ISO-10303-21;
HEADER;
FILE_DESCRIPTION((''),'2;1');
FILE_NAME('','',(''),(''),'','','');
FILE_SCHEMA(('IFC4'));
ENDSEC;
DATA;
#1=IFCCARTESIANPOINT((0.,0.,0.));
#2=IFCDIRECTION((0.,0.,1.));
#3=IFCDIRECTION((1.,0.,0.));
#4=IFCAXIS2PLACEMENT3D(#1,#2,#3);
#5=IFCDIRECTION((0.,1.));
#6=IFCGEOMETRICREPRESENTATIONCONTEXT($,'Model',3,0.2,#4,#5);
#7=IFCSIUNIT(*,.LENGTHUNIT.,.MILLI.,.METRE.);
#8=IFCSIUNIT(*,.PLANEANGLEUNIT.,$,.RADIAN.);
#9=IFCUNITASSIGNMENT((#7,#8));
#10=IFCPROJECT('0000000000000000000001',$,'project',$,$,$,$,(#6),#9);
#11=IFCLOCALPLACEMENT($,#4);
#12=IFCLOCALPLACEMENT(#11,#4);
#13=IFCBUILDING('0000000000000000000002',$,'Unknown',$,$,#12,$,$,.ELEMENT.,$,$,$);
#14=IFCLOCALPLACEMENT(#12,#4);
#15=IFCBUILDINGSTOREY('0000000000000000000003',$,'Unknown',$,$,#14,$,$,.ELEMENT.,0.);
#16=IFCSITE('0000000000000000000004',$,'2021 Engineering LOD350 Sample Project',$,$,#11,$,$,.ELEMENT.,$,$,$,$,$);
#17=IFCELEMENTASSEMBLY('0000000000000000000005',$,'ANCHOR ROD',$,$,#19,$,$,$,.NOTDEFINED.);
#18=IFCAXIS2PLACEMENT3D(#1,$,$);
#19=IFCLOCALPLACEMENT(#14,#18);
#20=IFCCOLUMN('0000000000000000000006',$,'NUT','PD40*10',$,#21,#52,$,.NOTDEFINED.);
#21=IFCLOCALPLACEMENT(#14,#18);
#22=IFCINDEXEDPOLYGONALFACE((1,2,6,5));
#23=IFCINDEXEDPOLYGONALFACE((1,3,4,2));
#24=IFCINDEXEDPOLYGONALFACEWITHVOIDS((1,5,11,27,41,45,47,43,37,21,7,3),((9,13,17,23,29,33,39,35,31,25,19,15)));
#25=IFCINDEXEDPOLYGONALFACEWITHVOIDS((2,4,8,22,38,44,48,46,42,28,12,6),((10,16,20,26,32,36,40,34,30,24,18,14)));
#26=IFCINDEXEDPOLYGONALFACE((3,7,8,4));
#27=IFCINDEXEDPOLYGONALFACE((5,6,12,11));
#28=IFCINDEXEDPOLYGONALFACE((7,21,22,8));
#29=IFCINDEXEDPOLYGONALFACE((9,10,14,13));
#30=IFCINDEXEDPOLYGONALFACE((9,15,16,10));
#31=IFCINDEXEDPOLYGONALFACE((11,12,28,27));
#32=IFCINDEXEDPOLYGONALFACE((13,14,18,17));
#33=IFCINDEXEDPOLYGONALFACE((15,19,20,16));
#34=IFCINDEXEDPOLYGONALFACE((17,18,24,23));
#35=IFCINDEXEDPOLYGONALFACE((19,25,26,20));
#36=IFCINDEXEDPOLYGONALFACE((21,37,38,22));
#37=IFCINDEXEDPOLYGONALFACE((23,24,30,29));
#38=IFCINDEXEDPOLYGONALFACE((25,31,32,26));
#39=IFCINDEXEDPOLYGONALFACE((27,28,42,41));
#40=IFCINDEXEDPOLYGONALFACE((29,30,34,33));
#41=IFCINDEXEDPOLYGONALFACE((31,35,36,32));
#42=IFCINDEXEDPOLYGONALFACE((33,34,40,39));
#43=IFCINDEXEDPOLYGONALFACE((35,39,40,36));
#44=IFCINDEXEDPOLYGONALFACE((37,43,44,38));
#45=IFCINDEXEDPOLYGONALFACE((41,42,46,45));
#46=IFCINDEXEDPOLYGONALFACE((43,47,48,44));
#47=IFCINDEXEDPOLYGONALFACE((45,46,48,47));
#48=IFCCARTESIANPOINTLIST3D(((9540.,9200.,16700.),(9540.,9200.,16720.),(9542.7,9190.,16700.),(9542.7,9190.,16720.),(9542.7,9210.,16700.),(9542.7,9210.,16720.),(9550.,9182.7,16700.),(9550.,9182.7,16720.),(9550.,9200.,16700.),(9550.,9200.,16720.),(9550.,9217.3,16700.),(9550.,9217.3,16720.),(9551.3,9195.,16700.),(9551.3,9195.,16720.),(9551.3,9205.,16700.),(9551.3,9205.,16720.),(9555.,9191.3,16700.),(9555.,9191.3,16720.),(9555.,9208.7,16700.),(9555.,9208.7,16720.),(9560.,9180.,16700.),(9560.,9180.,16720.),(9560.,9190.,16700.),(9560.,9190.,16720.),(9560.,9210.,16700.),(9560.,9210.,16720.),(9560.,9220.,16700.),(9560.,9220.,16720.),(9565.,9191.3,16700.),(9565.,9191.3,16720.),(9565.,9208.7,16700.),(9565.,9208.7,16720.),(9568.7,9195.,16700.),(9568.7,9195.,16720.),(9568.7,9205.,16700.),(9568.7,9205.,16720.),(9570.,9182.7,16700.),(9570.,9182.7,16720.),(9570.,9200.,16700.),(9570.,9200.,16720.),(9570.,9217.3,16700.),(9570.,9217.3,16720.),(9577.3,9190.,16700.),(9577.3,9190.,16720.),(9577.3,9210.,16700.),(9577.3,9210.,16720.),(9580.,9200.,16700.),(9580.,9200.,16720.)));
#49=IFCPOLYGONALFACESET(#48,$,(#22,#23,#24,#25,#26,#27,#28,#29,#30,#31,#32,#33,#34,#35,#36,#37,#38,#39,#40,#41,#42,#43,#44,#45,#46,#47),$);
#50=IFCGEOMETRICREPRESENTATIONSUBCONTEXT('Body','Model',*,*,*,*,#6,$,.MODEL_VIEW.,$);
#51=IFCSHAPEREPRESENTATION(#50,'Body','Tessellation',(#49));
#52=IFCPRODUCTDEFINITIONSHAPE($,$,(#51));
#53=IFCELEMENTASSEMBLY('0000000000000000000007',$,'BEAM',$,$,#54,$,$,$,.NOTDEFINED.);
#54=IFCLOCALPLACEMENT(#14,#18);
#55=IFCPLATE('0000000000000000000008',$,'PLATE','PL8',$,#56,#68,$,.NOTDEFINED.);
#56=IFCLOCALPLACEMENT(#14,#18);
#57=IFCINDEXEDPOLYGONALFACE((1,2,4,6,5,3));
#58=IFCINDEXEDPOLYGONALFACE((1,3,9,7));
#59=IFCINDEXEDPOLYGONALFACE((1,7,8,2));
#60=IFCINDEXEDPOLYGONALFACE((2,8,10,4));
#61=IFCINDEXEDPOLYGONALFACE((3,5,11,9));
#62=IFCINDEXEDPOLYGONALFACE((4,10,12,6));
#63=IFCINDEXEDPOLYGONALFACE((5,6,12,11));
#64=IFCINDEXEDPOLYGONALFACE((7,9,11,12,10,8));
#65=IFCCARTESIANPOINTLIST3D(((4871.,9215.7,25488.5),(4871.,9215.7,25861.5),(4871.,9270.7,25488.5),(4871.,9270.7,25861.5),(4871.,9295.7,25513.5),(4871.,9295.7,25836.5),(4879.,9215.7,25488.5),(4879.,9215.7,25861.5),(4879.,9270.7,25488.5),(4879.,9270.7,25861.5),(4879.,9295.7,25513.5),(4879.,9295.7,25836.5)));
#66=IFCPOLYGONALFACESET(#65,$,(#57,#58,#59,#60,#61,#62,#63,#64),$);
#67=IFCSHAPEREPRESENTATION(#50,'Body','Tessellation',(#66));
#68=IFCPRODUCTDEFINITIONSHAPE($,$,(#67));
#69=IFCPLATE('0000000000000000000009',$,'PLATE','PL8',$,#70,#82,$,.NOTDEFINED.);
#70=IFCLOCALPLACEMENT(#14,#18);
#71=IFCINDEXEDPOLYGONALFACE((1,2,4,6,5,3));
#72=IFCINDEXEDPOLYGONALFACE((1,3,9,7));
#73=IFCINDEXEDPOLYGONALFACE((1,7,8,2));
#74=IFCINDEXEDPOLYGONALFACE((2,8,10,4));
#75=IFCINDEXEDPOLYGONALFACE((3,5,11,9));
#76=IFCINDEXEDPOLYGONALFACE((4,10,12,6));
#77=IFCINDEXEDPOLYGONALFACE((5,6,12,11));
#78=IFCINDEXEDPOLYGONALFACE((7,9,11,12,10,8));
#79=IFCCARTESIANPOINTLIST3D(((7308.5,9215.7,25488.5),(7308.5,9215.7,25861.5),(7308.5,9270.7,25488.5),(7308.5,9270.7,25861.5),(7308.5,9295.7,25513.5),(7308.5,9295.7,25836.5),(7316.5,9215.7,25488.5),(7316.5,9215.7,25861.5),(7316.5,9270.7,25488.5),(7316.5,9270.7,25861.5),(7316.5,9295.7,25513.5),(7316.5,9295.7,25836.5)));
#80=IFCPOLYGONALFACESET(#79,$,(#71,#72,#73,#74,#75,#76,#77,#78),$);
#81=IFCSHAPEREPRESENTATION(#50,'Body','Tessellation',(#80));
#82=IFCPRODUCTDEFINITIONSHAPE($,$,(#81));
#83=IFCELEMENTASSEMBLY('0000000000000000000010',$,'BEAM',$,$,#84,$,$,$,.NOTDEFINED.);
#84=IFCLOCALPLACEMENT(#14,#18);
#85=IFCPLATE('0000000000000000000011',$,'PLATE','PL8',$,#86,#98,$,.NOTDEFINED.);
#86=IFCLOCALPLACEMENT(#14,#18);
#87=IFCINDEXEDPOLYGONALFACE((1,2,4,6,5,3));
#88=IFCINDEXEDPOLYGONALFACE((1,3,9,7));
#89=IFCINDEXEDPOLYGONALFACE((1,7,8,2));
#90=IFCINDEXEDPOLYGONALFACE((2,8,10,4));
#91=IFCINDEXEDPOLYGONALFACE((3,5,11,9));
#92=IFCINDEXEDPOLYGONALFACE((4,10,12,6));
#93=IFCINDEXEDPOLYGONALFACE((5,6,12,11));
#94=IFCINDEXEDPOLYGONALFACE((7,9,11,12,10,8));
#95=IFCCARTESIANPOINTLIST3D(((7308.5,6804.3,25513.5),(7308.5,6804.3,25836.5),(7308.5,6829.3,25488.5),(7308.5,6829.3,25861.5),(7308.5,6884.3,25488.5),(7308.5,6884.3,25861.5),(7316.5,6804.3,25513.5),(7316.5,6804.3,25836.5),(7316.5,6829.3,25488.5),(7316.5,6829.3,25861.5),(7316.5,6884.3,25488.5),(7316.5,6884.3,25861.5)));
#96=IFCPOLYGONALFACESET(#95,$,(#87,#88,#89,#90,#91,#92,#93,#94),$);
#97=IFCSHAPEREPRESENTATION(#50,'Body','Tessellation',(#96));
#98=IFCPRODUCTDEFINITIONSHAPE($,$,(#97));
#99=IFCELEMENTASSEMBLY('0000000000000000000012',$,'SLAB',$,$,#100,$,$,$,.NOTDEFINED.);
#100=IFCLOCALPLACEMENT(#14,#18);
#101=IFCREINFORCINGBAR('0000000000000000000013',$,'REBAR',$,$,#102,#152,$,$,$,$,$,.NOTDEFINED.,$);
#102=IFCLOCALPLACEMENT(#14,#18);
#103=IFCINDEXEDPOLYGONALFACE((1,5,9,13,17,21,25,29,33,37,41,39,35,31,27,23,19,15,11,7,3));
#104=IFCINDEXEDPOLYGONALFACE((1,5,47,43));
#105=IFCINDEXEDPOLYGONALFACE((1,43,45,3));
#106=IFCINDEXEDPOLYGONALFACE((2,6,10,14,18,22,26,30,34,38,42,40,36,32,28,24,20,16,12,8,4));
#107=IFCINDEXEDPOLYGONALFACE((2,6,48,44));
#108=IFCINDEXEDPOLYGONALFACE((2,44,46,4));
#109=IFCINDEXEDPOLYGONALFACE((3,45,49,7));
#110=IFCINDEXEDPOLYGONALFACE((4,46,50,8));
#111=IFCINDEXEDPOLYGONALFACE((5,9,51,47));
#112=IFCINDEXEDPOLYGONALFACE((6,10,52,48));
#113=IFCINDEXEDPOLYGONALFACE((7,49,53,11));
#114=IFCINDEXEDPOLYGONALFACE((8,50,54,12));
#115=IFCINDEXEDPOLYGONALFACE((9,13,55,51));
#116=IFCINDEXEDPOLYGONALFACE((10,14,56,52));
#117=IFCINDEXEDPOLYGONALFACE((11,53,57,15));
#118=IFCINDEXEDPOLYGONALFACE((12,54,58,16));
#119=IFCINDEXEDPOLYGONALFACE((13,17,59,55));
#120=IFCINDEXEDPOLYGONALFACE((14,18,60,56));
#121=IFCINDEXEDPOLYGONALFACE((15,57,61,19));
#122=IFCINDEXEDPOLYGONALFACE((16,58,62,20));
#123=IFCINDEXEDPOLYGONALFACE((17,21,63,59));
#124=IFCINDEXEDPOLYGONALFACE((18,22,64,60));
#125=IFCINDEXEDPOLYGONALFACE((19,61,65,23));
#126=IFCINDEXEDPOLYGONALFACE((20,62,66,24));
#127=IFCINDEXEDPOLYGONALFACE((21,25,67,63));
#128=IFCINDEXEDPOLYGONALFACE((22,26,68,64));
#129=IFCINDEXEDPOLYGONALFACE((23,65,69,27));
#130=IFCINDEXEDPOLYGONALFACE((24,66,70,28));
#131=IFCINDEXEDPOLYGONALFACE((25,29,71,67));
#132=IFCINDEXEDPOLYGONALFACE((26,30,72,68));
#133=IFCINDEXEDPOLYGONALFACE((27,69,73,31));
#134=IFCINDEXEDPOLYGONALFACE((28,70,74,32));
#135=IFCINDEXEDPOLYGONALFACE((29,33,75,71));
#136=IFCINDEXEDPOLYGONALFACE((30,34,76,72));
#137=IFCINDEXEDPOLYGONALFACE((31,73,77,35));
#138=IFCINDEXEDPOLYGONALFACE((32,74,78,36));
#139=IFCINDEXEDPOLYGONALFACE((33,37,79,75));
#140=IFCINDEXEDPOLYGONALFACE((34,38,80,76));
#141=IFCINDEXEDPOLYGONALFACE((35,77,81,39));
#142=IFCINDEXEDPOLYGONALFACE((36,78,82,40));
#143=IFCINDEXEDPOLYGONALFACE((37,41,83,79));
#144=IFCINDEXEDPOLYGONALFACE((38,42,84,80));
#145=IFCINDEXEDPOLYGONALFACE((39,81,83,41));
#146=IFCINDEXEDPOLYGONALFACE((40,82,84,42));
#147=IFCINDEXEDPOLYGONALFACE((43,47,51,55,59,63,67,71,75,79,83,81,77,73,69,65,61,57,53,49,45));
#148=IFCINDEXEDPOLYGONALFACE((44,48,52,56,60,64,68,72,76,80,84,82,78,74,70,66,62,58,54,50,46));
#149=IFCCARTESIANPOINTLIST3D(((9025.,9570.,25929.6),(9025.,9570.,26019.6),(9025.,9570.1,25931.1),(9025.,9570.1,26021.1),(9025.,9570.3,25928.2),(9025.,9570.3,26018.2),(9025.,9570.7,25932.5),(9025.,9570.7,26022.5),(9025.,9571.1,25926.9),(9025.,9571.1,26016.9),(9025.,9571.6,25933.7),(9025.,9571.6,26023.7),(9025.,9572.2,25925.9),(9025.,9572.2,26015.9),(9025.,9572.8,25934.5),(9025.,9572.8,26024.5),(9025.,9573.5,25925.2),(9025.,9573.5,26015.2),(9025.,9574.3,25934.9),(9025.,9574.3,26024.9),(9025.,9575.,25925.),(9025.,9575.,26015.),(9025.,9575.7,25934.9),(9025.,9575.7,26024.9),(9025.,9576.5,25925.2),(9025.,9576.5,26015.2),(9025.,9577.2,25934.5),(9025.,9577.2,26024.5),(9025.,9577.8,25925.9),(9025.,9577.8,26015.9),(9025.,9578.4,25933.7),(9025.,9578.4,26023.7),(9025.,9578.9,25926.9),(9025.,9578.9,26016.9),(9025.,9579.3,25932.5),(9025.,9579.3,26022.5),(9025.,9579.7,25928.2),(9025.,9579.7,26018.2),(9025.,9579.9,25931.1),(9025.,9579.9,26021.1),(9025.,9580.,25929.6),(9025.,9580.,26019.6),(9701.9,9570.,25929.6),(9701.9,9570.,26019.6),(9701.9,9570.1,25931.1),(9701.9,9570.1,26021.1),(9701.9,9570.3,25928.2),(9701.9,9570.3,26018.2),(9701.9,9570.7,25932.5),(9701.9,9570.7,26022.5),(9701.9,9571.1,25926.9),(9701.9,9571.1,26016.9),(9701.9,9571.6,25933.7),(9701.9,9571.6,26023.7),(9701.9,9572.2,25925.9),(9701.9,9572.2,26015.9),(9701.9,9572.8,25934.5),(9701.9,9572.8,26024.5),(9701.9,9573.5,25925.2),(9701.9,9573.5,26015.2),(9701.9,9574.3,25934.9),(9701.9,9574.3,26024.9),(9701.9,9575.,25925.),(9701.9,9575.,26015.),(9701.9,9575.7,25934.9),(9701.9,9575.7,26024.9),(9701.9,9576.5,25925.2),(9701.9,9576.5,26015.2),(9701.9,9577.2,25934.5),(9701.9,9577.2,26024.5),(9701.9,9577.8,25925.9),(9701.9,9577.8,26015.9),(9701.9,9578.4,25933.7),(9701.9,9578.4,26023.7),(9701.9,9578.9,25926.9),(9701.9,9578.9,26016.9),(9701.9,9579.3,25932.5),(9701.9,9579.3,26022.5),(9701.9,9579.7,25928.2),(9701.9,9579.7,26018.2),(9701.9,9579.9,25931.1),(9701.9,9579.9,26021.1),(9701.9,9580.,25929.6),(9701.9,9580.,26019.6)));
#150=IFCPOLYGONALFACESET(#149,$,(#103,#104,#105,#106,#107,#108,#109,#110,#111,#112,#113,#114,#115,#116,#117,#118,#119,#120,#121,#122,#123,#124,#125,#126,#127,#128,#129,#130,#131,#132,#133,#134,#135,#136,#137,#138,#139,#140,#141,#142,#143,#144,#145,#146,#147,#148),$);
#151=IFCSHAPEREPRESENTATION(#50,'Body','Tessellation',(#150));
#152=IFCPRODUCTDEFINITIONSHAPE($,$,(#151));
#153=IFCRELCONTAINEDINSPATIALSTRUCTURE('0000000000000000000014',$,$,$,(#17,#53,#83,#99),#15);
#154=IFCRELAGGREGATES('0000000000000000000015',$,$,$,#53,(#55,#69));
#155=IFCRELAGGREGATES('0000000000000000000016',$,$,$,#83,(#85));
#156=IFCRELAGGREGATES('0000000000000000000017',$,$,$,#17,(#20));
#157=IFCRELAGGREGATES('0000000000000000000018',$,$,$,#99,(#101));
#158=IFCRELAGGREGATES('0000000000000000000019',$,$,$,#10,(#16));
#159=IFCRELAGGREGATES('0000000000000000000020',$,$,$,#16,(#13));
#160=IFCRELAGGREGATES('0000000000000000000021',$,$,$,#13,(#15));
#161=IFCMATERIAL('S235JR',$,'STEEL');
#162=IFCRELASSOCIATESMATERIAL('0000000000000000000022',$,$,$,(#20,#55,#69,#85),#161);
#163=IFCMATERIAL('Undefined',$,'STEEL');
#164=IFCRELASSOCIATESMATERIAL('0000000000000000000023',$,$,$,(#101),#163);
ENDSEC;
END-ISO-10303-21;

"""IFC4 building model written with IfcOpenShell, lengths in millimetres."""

from ifc_helpers import new_model, entity, si_unit, direction, frame, origin_with_axes, place, context, subcontext, project, spatial, line, indexed_curve, outline, extrude, source, transform, mapped, material, element, aggregate, save


model = new_model("IFC4")

# Units and contexts
model_context = context("Model", 3, precision=0.2, world=origin_with_axes(), true_north=direction((0.0, 1.0)))
body_context = subcontext(model_context, "Body", "Model", "MODEL_VIEW")
ifc_project = project(units=[si_unit("LENGTHUNIT", "METRE", prefix="MILLI"), si_unit("PLANEANGLEUNIT", "RADIAN")], contexts=[model_context])

# Site, building, storey
site_placement = place(None, origin_with_axes())
site = spatial("IfcSite", under=ifc_project, at=site_placement, Name="2021 Engineering LOD350 Sample Project", CompositionType="ELEMENT")
building_placement = place(site_placement, origin_with_axes())
building = spatial("IfcBuilding", under=site, at=building_placement, Name="Unknown", CompositionType="ELEMENT")
storey_placement = place(building_placement, origin_with_axes())
storey = spatial("IfcBuildingStorey", under=building, at=storey_placement, Name="Unknown", CompositionType="ELEMENT", Elevation=0.0)

# Shared definitions
ifc_material_1 = material(Name="S235JR", Category="STEEL")

# Element assembly, column
assembly_1_placement = place(storey_placement, frame((9940.0, 9400.0, 16730.0), z_axis=(1.0, 0.0, 0.0), x_axis=(0.0, 0.0, -1.0)))
assembly_1 = element("IfcElementAssembly", 1, at=assembly_1_placement, inside=storey, Name="ANCHOR ROD", PredefinedType="NOTDEFINED")
column_1_placement = place(assembly_1_placement, frame((10.0, -200.0, -380.0), z_axis=(0.0, 0.0, -1.0), x_axis=(1.0, 0.0, 0.0)))
column_1 = element("IfcColumn", 2, at=column_1_placement, material=ifc_material_1, Name="NUT", Description="PD40*10", PredefinedType="NOTDEFINED", context=body_context, shape_type="SolidModel", body=[
    extrude(outline(indexed_curve([(20.0, 0.0), (17.3, 10.0), (10.0, 17.3), (0.0, 20.0), (-10.0, 17.3), (-17.3, 10.0), (-20.0, 0.0), (-17.3, -10.0), (-10.0, -17.3), (0.0, -20.0), (10.0, -17.3), (17.3, -10.0)], segments=[line(1, 2, 3, 4, 5, 6, 7, 8, 9, 10, 11, 12, 1)]), holes=[indexed_curve([(10.0, 0.0), (8.7, -5.0), (5.0, -8.7), (0.0, -10.0), (-5.0, -8.7), (-8.7, -5.0), (-10.0, 0.0), (-8.7, 5.0), (-5.0, 8.7), (0.0, 10.0), (5.0, 8.7), (8.7, 5.0)], segments=[line(1, 2, 3, 4, 5, 6, 7, 8, 9, 10, 11, 12, 1)])]), frame((0.0, 0.0, 0.0), z_axis=(-1.0, 0.0, 0.0), x_axis=(0.0, 0.0, 1.0)), (0.0, 0.0, -1.0), 20.0),
])

# Element assembly, plates
assembly_2_placement = place(storey_placement, frame((0.0, 9300.0, 25675.0), z_axis=(0.0, -1.0, 0.0), x_axis=(1.0, 0.0, 0.0)))
assembly_2 = element("IfcElementAssembly", 3, at=assembly_2_placement, inside=storey, Name="BEAM", PredefinedType="NOTDEFINED")
plate_1_placement = place(assembly_2_placement, frame((4875.0, -186.5, 4.3), z_axis=(-1.0, 0.0, 0.0), x_axis=(0.0, 0.0, 1.0)))
plate_1 = element("IfcPlate", 4, at=plate_1_placement, material=ifc_material_1, Name="PLATE", Description="PL8", PredefinedType="NOTDEFINED", context=body_context, shape_type="SolidModel", body=[
    extrude(outline(indexed_curve([(0.0, 25.0), (25.0, 0.0), (80.0, 0.0), (80.0, 373.0), (25.0, 373.0), (0.0, 348.0)], segments=[line(1, 2, 3, 4, 5, 6, 1)])), frame((0.0, 0.0, 4.0), z_axis=(0.0, 0.0, 1.0), x_axis=(1.0, 0.0, 0.0)), (0.0, 0.0, -1.0), 8.0),
])
plate_2_placement = place(assembly_2_placement, frame((7312.5, -186.5, 4.3), z_axis=(-1.0, 0.0, 0.0), x_axis=(0.0, 0.0, 1.0)))
plate_2 = element("IfcPlate", 5, at=plate_2_placement, material=ifc_material_1, Name="PLATE", Description="PL8", PredefinedType="NOTDEFINED", context=body_context, shape_type="SolidModel", body=[
    extrude(outline(indexed_curve([(0.0, 25.0), (25.0, 0.0), (80.0, 0.0), (80.0, 373.0), (25.0, 373.0), (0.0, 348.0)], segments=[line(1, 2, 3, 4, 5, 6, 1)])), frame((0.0, 0.0, 4.0), z_axis=(0.0, 0.0, 1.0), x_axis=(1.0, 0.0, 0.0)), (0.0, 0.0, -1.0), 8.0),
])
aggregate(assembly_2, [plate_1, plate_2])

# Element assembly, plate
assembly_3_placement = place(storey_placement, frame((0.0, 6800.0, 25675.0), z_axis=(0.0, -1.0, 0.0), x_axis=(1.0, 0.0, 0.0)))
assembly_3 = element("IfcElementAssembly", 6, at=assembly_3_placement, inside=storey, Name="BEAM", PredefinedType="NOTDEFINED")
plate_3_placement = place(assembly_3_placement, frame((7312.5, -186.5, -4.3), z_axis=(1.0, 0.0, 0.0), x_axis=(0.0, 0.0, -1.0)))
plate_3 = element("IfcPlate", 7, at=plate_3_placement, material=ifc_material_1, Name="PLATE", Description="PL8", PredefinedType="NOTDEFINED", context=body_context, shape_type="SolidModel", body=[
    extrude(outline(indexed_curve([(0.0, 25.0), (25.0, 0.0), (80.0, 0.0), (80.0, 373.0), (25.0, 373.0), (0.0, 348.0)], segments=[line(1, 2, 3, 4, 5, 6, 1)])), frame((0.0, 0.0, 4.0), z_axis=(0.0, 0.0, 1.0), x_axis=(1.0, 0.0, 0.0)), (0.0, 0.0, -1.0), 8.0),
])
aggregate(assembly_3, [plate_3])

# Element assembly, reinforcing bar
assembly_4_placement = place(storey_placement, frame((0.0, 19194.4, 25975.0), z_axis=(0.0, 0.0, 1.0), x_axis=(0.0, -1.0, 0.0)))
assembly_4 = element("IfcElementAssembly", 8, at=assembly_4_placement, inside=storey, Name="SLAB", PredefinedType="NOTDEFINED")
ifc_material_2 = material(Name="Undefined", Category="STEEL")
shared_shape_1 = source(origin_with_axes(), body_context, "Body", "AdvancedSweptSolid", [
    entity("IfcSweptDiskSolid", entity("IfcIndexedPolyCurve", entity("IfcCartesianPointList3D", [[0.0, 0.0, 0.0], [676.9, 0.0, 0.0]]), [entity("IfcLineIndex", [1, 2])]), 5.0),
])
reinforcing_bar_1_placement = place(assembly_4_placement, frame((9619.4, 9025.0, -45.0), z_axis=(0.0, 0.0, -1.0), x_axis=(0.0, 1.0, 0.0)))
reinforcing_bar_1 = element("IfcReinforcingBar", 9, at=reinforcing_bar_1_placement, material=ifc_material_2, Name="REBAR", PredefinedType="NOTDEFINED", context=body_context, shape_type="MappedRepresentation", body=[
    mapped(shared_shape_1, transform((0.0, 0.0, 0.0))),
    mapped(shared_shape_1, transform((0.0, 0.0, -90.0))),
])

aggregate(assembly_1, [column_1])

aggregate(assembly_4, [reinforcing_bar_1])

save(model, "model.ifc")
